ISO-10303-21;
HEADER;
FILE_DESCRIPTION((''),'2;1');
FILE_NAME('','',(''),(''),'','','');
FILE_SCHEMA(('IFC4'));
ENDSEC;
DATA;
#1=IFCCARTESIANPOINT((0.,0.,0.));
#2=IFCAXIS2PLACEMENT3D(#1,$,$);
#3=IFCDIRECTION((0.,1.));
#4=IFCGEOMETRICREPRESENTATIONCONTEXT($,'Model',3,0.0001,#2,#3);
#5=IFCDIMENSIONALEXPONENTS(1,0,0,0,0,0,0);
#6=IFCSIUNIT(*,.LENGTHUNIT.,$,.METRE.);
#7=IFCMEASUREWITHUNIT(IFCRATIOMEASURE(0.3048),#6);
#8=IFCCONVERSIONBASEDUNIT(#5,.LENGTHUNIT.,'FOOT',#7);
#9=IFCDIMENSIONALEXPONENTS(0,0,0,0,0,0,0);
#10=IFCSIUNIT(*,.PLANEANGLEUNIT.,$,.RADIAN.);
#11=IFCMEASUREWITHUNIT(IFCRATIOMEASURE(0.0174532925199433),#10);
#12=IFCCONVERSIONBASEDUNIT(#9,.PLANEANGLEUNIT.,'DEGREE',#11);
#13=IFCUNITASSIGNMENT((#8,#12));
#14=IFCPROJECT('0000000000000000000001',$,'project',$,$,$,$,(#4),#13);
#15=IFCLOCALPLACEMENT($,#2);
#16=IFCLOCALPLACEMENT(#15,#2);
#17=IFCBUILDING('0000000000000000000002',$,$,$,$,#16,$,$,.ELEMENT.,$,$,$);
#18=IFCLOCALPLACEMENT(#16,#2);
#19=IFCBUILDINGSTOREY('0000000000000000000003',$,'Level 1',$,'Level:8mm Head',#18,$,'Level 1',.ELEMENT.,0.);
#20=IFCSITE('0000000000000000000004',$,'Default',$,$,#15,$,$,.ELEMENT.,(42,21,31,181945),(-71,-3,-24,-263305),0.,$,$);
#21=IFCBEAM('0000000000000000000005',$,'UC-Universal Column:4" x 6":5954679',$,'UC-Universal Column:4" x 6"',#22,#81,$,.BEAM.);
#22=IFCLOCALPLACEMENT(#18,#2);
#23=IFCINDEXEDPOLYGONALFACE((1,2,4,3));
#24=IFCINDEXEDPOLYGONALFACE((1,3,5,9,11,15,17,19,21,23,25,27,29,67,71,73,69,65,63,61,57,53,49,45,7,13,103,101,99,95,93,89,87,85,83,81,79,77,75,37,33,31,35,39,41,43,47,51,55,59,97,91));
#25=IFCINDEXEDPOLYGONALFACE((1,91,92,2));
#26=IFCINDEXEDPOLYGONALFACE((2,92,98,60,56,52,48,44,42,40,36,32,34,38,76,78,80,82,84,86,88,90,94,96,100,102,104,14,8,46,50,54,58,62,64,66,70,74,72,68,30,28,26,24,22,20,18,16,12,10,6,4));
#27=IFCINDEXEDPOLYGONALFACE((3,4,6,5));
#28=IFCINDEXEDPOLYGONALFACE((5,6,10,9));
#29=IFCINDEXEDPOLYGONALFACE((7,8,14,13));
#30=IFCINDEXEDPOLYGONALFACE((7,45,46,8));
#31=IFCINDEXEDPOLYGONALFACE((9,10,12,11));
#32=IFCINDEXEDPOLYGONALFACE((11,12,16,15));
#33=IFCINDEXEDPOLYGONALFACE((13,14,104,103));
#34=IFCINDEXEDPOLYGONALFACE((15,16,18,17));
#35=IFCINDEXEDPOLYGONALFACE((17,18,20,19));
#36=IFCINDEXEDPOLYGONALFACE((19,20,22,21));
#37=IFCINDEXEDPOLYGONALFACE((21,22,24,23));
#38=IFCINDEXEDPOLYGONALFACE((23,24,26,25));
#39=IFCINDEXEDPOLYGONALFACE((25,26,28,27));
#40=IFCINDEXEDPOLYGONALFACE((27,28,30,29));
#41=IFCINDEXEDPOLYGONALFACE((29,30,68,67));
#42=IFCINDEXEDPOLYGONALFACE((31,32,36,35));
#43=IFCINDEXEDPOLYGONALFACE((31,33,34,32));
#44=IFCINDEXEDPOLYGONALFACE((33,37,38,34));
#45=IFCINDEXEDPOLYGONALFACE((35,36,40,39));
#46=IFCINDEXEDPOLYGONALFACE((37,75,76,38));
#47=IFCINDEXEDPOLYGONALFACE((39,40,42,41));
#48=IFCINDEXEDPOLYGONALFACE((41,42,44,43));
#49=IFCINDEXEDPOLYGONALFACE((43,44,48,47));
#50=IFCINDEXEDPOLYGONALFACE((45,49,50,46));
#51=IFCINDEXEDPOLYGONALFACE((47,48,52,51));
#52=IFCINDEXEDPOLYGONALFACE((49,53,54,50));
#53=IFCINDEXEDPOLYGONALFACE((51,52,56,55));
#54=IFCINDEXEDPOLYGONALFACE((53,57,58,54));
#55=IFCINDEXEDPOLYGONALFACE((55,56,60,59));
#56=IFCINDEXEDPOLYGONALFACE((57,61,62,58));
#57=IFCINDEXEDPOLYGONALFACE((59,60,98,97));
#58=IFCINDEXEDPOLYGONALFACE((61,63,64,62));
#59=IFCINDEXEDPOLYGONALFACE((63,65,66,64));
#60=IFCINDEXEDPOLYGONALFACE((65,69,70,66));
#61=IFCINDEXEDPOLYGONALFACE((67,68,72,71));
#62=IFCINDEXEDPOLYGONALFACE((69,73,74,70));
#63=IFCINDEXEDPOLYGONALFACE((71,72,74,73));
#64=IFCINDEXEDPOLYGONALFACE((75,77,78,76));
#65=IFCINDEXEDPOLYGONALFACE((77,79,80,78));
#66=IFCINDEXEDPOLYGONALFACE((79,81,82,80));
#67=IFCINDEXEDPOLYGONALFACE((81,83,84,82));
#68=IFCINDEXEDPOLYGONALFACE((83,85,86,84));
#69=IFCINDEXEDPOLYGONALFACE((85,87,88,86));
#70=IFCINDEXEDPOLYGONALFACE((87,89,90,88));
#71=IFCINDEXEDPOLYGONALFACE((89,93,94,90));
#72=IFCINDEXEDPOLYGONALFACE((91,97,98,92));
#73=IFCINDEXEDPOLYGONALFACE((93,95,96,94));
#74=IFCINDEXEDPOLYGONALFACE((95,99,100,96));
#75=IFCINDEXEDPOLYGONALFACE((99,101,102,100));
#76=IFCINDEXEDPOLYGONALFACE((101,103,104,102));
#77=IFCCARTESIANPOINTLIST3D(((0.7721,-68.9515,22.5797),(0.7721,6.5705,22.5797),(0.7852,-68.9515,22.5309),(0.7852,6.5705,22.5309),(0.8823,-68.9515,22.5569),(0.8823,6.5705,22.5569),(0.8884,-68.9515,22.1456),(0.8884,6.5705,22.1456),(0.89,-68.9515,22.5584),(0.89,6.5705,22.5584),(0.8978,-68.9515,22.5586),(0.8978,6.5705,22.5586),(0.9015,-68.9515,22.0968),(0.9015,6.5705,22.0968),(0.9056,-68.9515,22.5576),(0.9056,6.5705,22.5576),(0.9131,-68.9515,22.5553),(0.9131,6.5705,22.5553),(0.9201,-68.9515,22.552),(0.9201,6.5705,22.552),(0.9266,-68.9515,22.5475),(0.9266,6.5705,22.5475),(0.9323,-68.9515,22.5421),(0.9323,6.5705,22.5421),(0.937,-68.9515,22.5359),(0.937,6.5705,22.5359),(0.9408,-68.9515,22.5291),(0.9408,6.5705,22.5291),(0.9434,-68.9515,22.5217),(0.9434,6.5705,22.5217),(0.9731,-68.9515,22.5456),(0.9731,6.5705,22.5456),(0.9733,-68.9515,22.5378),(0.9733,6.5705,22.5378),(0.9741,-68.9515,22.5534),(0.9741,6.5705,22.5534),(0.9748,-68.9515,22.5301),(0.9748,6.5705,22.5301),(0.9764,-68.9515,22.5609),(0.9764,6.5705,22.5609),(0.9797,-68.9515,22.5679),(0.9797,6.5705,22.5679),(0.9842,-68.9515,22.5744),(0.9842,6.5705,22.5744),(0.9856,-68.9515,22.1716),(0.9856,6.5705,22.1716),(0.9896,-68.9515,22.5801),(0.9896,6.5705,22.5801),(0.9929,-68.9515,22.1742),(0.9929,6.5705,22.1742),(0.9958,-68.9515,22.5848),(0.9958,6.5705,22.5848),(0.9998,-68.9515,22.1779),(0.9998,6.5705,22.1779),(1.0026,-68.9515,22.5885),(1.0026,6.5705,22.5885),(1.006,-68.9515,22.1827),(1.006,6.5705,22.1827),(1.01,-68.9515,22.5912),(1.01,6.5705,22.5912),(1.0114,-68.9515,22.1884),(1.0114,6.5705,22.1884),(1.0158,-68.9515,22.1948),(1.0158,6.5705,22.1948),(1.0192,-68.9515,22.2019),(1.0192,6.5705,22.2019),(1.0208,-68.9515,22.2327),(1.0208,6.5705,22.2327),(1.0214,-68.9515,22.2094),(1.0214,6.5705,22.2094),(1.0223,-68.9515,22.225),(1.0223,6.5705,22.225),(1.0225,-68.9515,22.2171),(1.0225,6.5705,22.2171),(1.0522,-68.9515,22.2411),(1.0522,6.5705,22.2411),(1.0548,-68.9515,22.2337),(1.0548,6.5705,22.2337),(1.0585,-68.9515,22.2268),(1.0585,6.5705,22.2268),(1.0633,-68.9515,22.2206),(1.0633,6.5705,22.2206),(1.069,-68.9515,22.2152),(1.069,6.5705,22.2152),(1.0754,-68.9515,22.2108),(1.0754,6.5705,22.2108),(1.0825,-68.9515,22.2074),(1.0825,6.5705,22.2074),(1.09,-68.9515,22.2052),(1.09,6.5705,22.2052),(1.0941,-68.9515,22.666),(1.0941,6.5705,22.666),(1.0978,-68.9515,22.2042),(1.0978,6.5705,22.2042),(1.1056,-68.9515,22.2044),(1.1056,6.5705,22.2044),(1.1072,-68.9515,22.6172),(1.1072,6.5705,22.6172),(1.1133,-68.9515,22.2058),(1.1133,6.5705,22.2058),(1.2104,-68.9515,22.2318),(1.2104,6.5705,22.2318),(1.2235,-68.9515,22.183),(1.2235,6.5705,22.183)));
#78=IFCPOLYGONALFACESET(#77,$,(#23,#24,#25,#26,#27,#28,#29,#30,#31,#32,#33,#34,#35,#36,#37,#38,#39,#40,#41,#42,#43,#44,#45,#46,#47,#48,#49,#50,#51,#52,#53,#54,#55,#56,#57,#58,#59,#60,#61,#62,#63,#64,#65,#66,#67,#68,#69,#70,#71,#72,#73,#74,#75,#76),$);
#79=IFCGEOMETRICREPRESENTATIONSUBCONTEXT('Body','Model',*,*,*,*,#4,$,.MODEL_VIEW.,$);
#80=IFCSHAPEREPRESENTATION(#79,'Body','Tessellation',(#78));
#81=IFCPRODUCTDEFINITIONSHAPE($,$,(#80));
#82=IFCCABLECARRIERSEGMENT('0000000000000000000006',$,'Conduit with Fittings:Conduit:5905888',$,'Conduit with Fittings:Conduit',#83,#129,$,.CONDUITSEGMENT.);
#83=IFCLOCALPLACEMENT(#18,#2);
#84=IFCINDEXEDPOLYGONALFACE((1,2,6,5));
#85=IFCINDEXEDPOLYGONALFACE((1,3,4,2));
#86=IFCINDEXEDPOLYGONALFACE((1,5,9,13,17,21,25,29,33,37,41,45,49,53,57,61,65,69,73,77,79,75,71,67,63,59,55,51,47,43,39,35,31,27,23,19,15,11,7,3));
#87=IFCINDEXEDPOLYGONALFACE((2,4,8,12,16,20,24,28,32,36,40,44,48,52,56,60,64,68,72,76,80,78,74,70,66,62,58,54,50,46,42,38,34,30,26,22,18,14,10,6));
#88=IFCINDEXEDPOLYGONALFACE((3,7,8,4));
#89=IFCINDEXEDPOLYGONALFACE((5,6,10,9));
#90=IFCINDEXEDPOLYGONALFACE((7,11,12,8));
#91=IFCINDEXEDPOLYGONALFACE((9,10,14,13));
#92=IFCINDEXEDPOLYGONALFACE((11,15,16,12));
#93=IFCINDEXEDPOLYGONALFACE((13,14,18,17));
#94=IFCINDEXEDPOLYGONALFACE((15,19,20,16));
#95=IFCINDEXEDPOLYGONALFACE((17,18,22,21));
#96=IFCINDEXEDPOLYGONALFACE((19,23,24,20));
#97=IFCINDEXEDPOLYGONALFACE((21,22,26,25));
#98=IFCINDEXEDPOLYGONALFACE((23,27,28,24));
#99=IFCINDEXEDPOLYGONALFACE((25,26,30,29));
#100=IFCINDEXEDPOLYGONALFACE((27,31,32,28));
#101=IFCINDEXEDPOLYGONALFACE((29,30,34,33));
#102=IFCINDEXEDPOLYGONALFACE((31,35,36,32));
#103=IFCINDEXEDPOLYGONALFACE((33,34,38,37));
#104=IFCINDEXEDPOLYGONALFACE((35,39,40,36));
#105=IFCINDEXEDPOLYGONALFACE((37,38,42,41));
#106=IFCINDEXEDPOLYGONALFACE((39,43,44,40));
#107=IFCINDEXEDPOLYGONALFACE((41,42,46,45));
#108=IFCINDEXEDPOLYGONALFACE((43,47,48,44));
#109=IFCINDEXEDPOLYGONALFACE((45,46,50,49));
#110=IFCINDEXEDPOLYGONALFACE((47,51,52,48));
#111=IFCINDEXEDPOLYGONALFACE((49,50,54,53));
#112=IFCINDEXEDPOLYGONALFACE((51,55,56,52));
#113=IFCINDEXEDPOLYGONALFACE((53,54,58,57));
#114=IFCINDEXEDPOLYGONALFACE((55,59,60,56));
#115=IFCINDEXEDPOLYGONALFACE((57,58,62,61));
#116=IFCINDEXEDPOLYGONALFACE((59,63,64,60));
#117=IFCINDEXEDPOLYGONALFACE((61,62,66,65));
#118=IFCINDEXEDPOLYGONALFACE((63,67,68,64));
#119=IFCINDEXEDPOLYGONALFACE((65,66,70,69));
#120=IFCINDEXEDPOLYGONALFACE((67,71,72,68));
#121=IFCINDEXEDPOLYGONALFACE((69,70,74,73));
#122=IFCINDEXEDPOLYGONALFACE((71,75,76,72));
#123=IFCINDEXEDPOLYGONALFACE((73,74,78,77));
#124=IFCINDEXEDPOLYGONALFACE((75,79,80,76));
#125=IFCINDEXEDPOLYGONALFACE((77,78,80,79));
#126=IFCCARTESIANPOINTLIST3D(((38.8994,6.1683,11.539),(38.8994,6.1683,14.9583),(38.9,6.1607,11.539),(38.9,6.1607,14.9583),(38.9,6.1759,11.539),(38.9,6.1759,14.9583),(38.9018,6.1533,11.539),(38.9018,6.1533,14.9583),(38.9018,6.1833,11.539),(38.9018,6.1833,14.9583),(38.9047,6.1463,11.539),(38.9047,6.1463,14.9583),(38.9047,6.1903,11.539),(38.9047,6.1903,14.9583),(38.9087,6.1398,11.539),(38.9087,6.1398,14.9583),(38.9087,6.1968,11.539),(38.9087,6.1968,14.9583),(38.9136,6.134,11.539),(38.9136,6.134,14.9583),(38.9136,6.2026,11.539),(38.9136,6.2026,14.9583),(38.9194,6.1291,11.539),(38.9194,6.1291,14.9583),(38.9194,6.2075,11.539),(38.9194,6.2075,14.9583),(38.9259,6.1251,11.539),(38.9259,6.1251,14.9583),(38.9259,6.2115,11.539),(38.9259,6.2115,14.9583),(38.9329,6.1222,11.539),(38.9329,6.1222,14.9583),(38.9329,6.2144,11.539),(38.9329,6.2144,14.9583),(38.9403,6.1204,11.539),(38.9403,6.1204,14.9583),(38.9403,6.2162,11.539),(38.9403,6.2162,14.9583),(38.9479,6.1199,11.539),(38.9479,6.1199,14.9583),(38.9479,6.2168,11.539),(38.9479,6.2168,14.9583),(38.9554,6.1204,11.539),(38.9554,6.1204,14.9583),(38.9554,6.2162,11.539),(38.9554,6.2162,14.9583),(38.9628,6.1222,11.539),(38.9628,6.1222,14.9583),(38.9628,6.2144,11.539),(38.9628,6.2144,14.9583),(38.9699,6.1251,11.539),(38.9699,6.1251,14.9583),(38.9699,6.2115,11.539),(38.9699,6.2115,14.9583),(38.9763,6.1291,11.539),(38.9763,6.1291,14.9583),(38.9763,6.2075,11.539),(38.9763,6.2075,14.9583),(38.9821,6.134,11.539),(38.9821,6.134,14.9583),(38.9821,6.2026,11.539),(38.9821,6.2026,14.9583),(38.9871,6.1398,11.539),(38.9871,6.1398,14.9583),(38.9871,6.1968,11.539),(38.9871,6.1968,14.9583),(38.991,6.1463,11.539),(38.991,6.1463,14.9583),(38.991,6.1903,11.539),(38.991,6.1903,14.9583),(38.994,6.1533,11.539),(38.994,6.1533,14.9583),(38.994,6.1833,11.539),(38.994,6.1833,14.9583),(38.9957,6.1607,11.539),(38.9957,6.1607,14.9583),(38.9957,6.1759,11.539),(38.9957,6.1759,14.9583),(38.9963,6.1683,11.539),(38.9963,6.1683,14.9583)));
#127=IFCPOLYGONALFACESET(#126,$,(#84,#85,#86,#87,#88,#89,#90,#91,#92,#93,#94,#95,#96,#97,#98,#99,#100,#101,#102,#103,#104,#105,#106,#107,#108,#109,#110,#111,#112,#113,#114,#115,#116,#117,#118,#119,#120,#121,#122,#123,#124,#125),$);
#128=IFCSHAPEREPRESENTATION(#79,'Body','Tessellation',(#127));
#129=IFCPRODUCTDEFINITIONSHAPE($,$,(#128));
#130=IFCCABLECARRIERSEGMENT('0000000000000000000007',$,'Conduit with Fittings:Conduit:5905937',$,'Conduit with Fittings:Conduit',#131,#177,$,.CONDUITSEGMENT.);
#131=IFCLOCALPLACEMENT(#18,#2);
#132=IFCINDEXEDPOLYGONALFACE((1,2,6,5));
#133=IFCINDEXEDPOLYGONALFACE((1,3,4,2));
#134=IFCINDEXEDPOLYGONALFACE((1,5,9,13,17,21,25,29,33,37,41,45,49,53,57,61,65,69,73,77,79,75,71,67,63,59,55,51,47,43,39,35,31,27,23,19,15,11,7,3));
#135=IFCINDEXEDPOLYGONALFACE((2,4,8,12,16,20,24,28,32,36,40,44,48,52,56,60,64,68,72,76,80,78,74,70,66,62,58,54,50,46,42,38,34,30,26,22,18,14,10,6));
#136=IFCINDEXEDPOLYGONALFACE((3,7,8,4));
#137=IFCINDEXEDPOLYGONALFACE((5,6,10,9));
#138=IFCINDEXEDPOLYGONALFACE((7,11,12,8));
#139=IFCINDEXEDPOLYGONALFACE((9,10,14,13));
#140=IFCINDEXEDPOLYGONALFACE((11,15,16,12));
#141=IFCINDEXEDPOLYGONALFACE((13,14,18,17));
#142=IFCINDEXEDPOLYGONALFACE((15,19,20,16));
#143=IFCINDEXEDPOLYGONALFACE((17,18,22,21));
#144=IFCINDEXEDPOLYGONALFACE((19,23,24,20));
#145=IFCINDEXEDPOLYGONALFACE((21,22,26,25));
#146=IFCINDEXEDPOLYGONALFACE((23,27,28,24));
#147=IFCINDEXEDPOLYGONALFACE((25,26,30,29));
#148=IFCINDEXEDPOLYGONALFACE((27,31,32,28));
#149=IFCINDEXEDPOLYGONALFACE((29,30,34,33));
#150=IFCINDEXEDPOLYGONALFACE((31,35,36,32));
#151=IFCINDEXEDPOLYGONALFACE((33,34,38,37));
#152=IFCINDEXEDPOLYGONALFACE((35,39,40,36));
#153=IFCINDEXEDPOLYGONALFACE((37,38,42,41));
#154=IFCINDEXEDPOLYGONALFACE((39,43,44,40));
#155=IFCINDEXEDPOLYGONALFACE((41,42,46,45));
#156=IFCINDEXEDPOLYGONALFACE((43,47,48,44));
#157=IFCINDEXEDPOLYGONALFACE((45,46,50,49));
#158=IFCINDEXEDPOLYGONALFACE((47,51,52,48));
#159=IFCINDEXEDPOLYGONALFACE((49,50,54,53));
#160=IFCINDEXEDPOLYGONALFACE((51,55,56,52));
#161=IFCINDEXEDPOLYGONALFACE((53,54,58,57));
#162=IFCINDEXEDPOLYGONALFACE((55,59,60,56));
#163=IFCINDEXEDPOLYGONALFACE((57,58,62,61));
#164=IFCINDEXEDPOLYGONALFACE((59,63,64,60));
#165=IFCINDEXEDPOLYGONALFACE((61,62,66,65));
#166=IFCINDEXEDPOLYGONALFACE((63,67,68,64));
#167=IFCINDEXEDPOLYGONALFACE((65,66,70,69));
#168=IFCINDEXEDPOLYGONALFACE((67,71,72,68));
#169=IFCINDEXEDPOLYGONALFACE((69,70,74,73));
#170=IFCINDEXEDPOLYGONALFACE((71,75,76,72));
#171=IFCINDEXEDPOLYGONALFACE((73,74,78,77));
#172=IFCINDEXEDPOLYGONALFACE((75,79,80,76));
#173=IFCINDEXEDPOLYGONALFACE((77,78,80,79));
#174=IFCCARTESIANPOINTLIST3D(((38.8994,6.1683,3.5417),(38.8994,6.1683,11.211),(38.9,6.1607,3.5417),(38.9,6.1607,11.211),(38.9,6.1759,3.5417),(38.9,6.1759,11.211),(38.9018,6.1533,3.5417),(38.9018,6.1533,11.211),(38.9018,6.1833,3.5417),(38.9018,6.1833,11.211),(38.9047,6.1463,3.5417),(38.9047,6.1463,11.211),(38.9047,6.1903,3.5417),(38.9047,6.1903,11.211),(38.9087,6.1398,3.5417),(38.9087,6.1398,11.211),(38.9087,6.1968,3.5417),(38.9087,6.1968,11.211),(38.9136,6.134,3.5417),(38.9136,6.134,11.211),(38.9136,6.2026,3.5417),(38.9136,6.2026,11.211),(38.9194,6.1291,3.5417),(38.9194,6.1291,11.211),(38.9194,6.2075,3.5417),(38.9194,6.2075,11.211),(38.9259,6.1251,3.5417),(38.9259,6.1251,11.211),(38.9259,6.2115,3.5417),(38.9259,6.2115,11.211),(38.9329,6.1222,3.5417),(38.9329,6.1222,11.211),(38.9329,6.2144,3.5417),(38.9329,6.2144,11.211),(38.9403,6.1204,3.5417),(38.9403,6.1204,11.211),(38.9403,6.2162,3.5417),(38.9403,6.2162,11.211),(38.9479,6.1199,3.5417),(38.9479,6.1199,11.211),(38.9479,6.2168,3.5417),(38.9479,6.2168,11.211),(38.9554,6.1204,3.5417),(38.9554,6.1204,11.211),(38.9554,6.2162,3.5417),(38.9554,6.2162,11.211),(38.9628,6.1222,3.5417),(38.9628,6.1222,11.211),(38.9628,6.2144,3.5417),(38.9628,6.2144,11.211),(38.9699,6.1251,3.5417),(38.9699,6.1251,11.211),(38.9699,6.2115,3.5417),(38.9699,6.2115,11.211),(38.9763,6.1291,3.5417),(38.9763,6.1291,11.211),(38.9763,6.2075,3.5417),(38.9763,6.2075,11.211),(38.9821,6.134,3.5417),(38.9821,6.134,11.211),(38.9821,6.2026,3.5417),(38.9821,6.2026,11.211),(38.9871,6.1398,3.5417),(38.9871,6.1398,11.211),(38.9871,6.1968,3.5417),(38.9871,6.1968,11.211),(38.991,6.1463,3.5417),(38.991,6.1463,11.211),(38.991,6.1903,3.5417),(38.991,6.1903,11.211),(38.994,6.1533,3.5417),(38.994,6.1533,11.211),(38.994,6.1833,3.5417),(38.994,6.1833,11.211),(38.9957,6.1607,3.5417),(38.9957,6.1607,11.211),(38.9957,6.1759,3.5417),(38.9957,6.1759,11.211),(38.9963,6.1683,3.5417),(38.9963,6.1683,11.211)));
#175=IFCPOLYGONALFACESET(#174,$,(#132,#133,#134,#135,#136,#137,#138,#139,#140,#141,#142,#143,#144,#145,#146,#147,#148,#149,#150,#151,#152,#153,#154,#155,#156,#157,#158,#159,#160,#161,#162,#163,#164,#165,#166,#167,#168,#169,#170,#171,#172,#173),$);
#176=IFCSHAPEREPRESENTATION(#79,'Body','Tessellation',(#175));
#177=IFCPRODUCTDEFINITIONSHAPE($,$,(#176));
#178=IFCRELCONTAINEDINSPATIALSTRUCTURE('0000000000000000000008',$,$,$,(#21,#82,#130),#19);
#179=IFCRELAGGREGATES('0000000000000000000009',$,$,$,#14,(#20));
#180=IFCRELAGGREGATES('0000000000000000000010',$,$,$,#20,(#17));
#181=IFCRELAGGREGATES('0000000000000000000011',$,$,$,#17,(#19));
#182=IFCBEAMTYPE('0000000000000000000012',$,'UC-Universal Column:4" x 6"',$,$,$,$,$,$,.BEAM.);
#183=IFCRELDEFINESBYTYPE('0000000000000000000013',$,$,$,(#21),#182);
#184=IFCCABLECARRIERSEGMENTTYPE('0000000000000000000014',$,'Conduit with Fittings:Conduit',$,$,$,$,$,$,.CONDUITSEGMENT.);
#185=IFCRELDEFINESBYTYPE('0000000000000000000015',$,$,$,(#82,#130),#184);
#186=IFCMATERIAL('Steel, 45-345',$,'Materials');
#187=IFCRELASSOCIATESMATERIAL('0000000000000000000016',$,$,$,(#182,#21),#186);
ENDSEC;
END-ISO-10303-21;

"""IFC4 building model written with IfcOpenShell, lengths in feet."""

from ifc_helpers import new_model, entity, si_unit, converted_unit, direction, frame, origin, place, context, subcontext, project, spatial, indexed_curve, outline, extrude, source, transform, mapped, material, type_object, type_shapes, element, save


model = new_model("IFC4")

# Units and contexts
model_context = context("Model", 3, precision=0.0001, world=origin(), true_north=direction((0.0, 1.0)))
body_context = subcontext(model_context, "Body", "Model", "MODEL_VIEW")
ifc_project = project(units=[converted_unit("LENGTHUNIT", "FOOT", entity("IfcRatioMeasure", 0.3048), si_unit("LENGTHUNIT", "METRE"), dimensions=[1, 0, 0, 0, 0, 0, 0]), converted_unit("PLANEANGLEUNIT", "DEGREE", entity("IfcRatioMeasure", 0.0174532925199433), si_unit("PLANEANGLEUNIT", "RADIAN"), dimensions=[0, 0, 0, 0, 0, 0, 0])], contexts=[model_context])

# Site, building, storey
site_placement = place(None, origin())
site = spatial("IfcSite", under=ifc_project, at=site_placement, Name="Default", CompositionType="ELEMENT", RefLatitude=(42, 21, 31, 181945), RefLongitude=(-71, -3, -24, -263305), RefElevation=0.0)
building_placement = place(site_placement, origin())
building = spatial("IfcBuilding", under=site, at=building_placement, CompositionType="ELEMENT")
storey_placement = place(building_placement, origin())
storey = spatial("IfcBuildingStorey", under=building, at=storey_placement, Name="Level 1", ObjectType="Level:8mm Head", LongName="Level 1", CompositionType="ELEMENT", Elevation=0.0)

# Beam
ifc_material_1 = material(Name="Steel, 45-345", Category="Materials")
beam_type = type_object("IfcBeamType", Name="UC-Universal Column:4\" x 6\"", PredefinedType="BEAM", material=ifc_material_1)
shared_shape_1 = source(origin(), body_context, "Body", "SweptSolid", [
    extrude(outline(indexed_curve([(-0.25, -0.1667), (-0.1995, -0.1667), (-0.1995, -0.0661), (-0.1989, -0.0583), (-0.197, -0.0507), (-0.194, -0.0435), (-0.19, -0.0368), (-0.1849, -0.0308), (-0.1789, -0.0258), (-0.1722, -0.0217), (-0.165, -0.0187), (-0.1574, -0.0169), (-0.1496, -0.0162), (0.1496, -0.0162), (0.1574, -0.0169), (0.165, -0.0187), (0.1722, -0.0217), (0.1789, -0.0258), (0.1849, -0.0308), (0.19, -0.0368), (0.194, -0.0435), (0.197, -0.0507), (0.1989, -0.0583), (0.1995, -0.0661), (0.1995, -0.1667), (0.25, -0.1667), (0.25, 0.1667), (0.1995, 0.1667), (0.1995, 0.0661), (0.1989, 0.0583), (0.197, 0.0507), (0.194, 0.0435), (0.19, 0.0368), (0.1849, 0.0308), (0.1789, 0.0258), (0.1722, 0.0217), (0.165, 0.0187), (0.1574, 0.0169), (0.1496, 0.0162), (-0.1496, 0.0162), (-0.1574, 0.0169), (-0.165, 0.0187), (-0.1722, 0.0217), (-0.1789, 0.0258), (-0.1849, 0.0308), (-0.19, 0.0368), (-0.194, 0.0435), (-0.197, 0.0507), (-0.1989, 0.0583), (-0.1995, 0.0661), (-0.1995, 0.1667), (-0.25, 0.1667), (-0.25, -0.1667)], self_intersect=False)), frame((-40.7002, 0.0, 0.0), z_axis=(1.0, 0.0, 0.0), x_axis=(0.0, 0.0, -1.0)), (0.0, 0.0, 1.0), 75.5219),
])
type_shapes(beam_type, [shared_shape_1])
beam_placement = place(storey_placement, frame((0.9978, -34.1297, 22.3814), z_axis=(-0.258819, 0.0, 0.965926), x_axis=(0.0, -1.0, 0.0)))
element("IfcBeam", 1, at=beam_placement, inside=storey, type_object=beam_type, material=ifc_material_1, Name="UC-Universal Column:4\" x 6\":5954679", ObjectType="UC-Universal Column:4\" x 6\"", PredefinedType="BEAM", context=body_context, shape_type="MappedRepresentation", body=[
    mapped(shared_shape_1, transform((0.0, 0.0, 0.0), scale=1.0)),
])

# Cable carrier segments
cable_carrier_segment_type_1 = type_object("IfcCableCarrierSegmentType", Name="Conduit with Fittings:Conduit", PredefinedType="CONDUITSEGMENT")
cable_carrier_segment_1_placement = place(storey_placement, origin())
element("IfcCableCarrierSegment", 2, at=cable_carrier_segment_1_placement, inside=storey, type_object=cable_carrier_segment_type_1, Name="Conduit with Fittings:Conduit:5905888", ObjectType="Conduit with Fittings:Conduit", PredefinedType="CONDUITSEGMENT", context=body_context, shape_type="SweptSolid", body=[
    extrude(outline(indexed_curve([(0.0485, 0.0), (0.0479, 0.0076), (0.0461, 0.015), (0.0432, 0.022), (0.0392, 0.0285), (0.0343, 0.0343), (0.0285, 0.0392), (0.022, 0.0432), (0.015, 0.0461), (0.0076, 0.0479), (0.0, 0.0485), (-0.0076, 0.0479), (-0.015, 0.0461), (-0.022, 0.0432), (-0.0285, 0.0392), (-0.0343, 0.0343), (-0.0392, 0.0285), (-0.0432, 0.022), (-0.0461, 0.015), (-0.0479, 0.0076), (-0.0485, 0.0), (-0.0479, -0.0076), (-0.0461, -0.015), (-0.0432, -0.022), (-0.0392, -0.0285), (-0.0343, -0.0343), (-0.0285, -0.0392), (-0.022, -0.0432), (-0.015, -0.0461), (-0.0076, -0.0479), (0.0, -0.0485), (0.0076, -0.0479), (0.015, -0.0461), (0.022, -0.0432), (0.0285, -0.0392), (0.0343, -0.0343), (0.0392, -0.0285), (0.0432, -0.022), (0.0461, -0.015), (0.0479, -0.0076), (0.0485, 0.0)], self_intersect=False)), frame((38.9479, 6.1683, 11.539), z_axis=(0.0, 0.0, 1.0), x_axis=(-1.0, 0.0, 0.0)), (0.0, 0.0, 1.0), 3.4193),
])
cable_carrier_segment_2_placement = place(storey_placement, origin())
element("IfcCableCarrierSegment", 3, at=cable_carrier_segment_2_placement, inside=storey, type_object=cable_carrier_segment_type_1, Name="Conduit with Fittings:Conduit:5905937", ObjectType="Conduit with Fittings:Conduit", PredefinedType="CONDUITSEGMENT", context=body_context, shape_type="SweptSolid", body=[
    extrude(outline(indexed_curve([(0.0485, 0.0), (0.0479, 0.0076), (0.0461, 0.015), (0.0432, 0.022), (0.0392, 0.0285), (0.0343, 0.0343), (0.0285, 0.0392), (0.022, 0.0432), (0.015, 0.0461), (0.0076, 0.0479), (0.0, 0.0485), (-0.0076, 0.0479), (-0.015, 0.0461), (-0.022, 0.0432), (-0.0285, 0.0392), (-0.0343, 0.0343), (-0.0392, 0.0285), (-0.0432, 0.022), (-0.0461, 0.015), (-0.0479, 0.0076), (-0.0485, 0.0), (-0.0479, -0.0076), (-0.0461, -0.015), (-0.0432, -0.022), (-0.0392, -0.0285), (-0.0343, -0.0343), (-0.0285, -0.0392), (-0.022, -0.0432), (-0.015, -0.0461), (-0.0076, -0.0479), (0.0, -0.0485), (0.0076, -0.0479), (0.015, -0.0461), (0.022, -0.0432), (0.0285, -0.0392), (0.0343, -0.0343), (0.0392, -0.0285), (0.0432, -0.022), (0.0461, -0.015), (0.0479, -0.0076), (0.0485, 0.0)], self_intersect=False)), frame((38.9479, 6.1683, 3.5417), z_axis=(0.0, 0.0, 1.0), x_axis=(-1.0, 0.0, 0.0)), (0.0, 0.0, 1.0), 7.6693),
])

save(model, "model.ifc")
